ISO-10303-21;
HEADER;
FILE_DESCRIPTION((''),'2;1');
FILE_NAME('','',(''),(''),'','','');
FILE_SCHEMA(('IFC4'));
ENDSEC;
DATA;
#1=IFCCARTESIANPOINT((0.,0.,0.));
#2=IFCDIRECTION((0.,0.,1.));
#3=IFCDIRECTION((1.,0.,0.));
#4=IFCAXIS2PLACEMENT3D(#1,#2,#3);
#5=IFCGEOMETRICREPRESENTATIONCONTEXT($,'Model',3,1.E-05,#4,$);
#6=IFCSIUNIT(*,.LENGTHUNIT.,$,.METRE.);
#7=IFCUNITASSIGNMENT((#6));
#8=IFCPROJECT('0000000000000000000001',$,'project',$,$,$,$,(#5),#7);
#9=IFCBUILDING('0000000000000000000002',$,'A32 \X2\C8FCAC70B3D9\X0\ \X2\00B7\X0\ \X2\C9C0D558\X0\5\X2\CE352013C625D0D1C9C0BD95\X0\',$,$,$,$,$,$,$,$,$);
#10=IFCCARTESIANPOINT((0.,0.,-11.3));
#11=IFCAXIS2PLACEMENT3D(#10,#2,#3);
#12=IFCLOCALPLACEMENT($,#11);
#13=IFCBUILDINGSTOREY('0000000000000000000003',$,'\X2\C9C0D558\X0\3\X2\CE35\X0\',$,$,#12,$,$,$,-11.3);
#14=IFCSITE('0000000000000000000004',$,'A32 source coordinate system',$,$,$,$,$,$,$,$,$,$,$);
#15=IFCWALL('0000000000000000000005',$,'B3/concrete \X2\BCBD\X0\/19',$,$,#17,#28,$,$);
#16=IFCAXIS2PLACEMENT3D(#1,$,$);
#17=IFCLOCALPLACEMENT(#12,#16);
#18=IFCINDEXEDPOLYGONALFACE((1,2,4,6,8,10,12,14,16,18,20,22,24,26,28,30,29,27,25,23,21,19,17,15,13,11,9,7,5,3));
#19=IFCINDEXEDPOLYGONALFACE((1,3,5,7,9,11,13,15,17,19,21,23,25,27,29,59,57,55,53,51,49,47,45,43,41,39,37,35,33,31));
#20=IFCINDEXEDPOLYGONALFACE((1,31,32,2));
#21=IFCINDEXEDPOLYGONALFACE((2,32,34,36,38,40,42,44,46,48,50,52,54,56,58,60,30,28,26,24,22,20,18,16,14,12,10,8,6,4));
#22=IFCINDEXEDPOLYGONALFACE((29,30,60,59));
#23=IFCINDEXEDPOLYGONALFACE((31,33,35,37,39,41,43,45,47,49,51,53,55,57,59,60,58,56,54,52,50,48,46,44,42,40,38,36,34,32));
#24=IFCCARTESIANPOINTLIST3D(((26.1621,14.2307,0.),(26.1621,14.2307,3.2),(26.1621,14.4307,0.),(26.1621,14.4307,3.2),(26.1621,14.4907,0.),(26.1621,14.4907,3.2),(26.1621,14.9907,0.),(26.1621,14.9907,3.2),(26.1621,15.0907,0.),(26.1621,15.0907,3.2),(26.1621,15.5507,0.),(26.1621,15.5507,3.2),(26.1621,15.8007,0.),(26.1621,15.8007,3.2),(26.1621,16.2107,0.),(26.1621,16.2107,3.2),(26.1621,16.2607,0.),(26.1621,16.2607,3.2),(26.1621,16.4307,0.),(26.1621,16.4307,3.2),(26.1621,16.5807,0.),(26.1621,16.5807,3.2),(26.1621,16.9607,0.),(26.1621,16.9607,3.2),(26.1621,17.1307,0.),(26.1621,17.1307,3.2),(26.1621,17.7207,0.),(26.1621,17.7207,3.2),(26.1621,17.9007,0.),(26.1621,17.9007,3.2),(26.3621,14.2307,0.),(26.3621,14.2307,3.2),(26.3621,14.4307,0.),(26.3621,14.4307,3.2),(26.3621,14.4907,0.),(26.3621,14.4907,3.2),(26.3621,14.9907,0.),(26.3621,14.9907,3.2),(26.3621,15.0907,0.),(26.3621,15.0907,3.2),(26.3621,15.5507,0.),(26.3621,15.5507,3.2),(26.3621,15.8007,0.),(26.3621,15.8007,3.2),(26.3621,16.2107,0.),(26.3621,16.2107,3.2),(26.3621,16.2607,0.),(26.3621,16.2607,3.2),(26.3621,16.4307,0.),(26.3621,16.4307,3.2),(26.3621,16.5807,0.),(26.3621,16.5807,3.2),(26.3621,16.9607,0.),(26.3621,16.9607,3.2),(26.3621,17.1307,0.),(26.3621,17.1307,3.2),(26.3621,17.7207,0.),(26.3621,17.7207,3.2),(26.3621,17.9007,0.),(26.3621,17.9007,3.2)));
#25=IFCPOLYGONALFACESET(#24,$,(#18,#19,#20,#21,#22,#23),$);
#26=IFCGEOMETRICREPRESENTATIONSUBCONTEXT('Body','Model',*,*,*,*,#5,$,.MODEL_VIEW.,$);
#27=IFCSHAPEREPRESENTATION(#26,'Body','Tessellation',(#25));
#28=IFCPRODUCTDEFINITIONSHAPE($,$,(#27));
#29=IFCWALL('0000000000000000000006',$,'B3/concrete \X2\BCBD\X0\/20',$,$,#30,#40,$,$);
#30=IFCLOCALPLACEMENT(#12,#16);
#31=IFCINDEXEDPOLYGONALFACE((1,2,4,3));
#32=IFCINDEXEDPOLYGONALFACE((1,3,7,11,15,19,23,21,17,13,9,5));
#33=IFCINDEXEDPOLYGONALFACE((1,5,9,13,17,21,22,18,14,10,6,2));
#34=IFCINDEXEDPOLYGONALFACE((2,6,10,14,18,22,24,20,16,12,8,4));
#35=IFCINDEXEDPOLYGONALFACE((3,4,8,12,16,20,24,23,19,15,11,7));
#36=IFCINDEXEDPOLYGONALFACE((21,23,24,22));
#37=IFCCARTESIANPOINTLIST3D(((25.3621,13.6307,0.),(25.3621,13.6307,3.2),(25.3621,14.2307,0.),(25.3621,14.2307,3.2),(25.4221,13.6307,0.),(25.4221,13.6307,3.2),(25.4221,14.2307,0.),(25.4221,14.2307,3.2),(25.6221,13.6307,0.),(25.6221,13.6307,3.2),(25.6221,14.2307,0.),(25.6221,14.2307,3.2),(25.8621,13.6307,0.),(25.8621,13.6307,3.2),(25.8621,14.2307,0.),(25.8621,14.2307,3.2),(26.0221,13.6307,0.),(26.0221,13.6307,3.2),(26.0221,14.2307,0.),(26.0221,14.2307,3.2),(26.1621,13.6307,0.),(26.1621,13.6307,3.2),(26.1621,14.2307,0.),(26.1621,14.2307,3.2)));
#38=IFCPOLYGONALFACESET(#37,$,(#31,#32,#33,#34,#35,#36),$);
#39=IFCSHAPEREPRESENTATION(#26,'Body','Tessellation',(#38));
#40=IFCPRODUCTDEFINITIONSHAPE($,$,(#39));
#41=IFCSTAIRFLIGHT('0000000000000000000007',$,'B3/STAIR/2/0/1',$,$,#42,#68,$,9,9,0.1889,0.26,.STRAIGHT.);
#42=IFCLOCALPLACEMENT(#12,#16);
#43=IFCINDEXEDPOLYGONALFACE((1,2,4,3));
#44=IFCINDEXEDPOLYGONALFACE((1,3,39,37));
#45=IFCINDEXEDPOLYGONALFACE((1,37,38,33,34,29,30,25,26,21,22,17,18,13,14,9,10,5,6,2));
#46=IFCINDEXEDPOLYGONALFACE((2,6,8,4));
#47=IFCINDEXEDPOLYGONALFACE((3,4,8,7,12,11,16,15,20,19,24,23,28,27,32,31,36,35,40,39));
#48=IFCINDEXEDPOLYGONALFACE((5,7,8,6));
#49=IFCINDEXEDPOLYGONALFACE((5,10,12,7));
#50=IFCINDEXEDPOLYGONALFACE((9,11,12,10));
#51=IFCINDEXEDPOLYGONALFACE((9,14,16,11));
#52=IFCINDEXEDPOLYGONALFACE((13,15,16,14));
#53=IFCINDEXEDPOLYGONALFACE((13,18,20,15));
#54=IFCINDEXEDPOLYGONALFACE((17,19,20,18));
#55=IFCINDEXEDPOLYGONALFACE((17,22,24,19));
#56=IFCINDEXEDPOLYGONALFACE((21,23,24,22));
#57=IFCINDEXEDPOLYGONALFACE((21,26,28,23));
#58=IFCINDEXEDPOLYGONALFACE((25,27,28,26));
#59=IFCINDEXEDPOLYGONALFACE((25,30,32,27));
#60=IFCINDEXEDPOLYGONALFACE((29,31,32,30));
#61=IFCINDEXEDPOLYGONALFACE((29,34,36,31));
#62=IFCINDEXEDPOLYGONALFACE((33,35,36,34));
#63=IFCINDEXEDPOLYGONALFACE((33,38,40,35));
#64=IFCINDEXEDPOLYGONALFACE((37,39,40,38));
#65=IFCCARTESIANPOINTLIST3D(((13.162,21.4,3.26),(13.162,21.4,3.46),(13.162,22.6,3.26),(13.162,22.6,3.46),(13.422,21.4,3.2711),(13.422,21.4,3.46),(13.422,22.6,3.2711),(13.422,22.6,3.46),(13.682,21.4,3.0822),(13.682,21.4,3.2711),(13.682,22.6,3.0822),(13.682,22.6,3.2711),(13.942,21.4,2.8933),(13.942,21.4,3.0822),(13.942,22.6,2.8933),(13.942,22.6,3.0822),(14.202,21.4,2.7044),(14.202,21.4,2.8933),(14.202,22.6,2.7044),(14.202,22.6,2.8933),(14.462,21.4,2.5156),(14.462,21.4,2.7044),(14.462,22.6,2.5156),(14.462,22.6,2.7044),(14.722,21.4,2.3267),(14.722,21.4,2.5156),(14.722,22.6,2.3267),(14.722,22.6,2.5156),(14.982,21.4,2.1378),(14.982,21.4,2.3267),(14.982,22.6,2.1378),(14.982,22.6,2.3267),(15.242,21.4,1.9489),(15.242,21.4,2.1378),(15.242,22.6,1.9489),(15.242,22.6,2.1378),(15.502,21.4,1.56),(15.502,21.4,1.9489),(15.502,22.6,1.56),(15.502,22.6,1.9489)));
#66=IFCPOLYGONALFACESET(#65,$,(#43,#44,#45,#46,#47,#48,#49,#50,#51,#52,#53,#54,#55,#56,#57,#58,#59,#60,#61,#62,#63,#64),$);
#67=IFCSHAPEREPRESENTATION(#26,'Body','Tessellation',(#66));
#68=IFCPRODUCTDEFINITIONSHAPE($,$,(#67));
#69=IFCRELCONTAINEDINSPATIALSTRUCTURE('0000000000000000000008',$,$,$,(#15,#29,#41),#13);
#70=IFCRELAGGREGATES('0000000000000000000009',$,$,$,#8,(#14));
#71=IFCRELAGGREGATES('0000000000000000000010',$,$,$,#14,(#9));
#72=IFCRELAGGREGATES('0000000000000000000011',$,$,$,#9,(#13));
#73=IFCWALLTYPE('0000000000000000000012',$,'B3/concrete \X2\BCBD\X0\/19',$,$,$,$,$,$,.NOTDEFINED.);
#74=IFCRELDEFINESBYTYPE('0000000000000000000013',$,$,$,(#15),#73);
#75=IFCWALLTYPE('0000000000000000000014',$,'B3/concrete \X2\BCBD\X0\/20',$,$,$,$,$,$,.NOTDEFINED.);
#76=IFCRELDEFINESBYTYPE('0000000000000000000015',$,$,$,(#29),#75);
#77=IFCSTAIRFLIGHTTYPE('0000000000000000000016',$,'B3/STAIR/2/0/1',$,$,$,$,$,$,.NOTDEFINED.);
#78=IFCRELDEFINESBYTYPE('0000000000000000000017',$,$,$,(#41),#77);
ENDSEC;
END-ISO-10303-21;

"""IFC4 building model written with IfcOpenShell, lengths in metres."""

from ifc_helpers import new_model, si_unit, frame, origin, origin_with_axes, place, context, subcontext, project, spatial, polyline, outline, extrude, source, transform, mapped, type_object, type_shapes, element, save


model = new_model("IFC4")

# Units and contexts
model_context = context("Model", 3, precision=1e-05, world=origin_with_axes())
body_context = subcontext(model_context, "Body", "Model", "MODEL_VIEW")
ifc_project = project(units=[si_unit("LENGTHUNIT", "METRE")], contexts=[model_context])

# Site, building, storey
site = spatial("IfcSite", under=ifc_project, Name="A32 source coordinate system")
building = spatial("IfcBuilding", under=site, Name="A32 주거동 · 지하5층–옥탑지붕")
storey_placement = place(None, frame((0.0, 0.0, -11.3), z_axis=(0.0, 0.0, 1.0), x_axis=(1.0, 0.0, 0.0)))
storey = spatial("IfcBuildingStorey", under=building, at=storey_placement, Name="지하3층", Elevation=-11.3)

# Walls
wall_type_1 = type_object("IfcWallType", Name="B3/concrete 벽/19", PredefinedType="NOTDEFINED")
shared_shape_1 = source(origin(), body_context, "Body", "SweptSolid", [
    extrude(outline(polyline([(26.1621, 14.9907), (26.1621, 15.0907), (26.1621, 15.5507), (26.1621, 15.8007), (26.1621, 16.2107), (26.1621, 16.2607), (26.1621, 16.4307), (26.1621, 16.5807), (26.1621, 16.9607), (26.1621, 17.1307), (26.1621, 17.7207), (26.1621, 17.9007), (26.3621, 17.9007), (26.3621, 17.7207), (26.3621, 17.1307), (26.3621, 16.9607), (26.3621, 16.5807), (26.3621, 16.4307), (26.3621, 16.2607), (26.3621, 16.2107), (26.3621, 15.8007), (26.3621, 15.5507), (26.3621, 15.0907), (26.3621, 14.9907), (26.3621, 14.4907), (26.3621, 14.4307), (26.3621, 14.2307), (26.1621, 14.2307), (26.1621, 14.4307), (26.1621, 14.4907), (26.1621, 14.9907)])), origin(), (0.0, 0.0, 1.0), 3.2),
])
type_shapes(wall_type_1, [shared_shape_1])
wall_1_placement = place(storey_placement, origin_with_axes())
element("IfcWall", 1, at=wall_1_placement, inside=storey, type_object=wall_type_1, Name="B3/concrete 벽/19", context=body_context, shape_type="MappedRepresentation", body=[
    mapped(shared_shape_1, transform((0.0, 0.0, 0.0), scale=1.0)),
])
wall_type_2 = type_object("IfcWallType", Name="B3/concrete 벽/20", PredefinedType="NOTDEFINED")
shared_shape_2 = source(origin(), body_context, "Body", "SweptSolid", [
    extrude(outline(polyline([(25.8621, 13.6307), (25.6221, 13.6307), (25.4221, 13.6307), (25.3621, 13.6307), (25.3621, 14.2307), (25.4221, 14.2307), (25.6221, 14.2307), (25.8621, 14.2307), (26.0221, 14.2307), (26.1621, 14.2307), (26.1621, 13.6307), (26.0221, 13.6307), (25.8621, 13.6307)])), origin(), (0.0, 0.0, 1.0), 3.2),
])
type_shapes(wall_type_2, [shared_shape_2])
wall_2_placement = place(storey_placement, origin_with_axes())
element("IfcWall", 2, at=wall_2_placement, inside=storey, type_object=wall_type_2, Name="B3/concrete 벽/20", context=body_context, shape_type="MappedRepresentation", body=[
    mapped(shared_shape_2, transform((0.0, 0.0, 0.0), scale=1.0)),
])

# Stair flight
stair_flight_type = type_object("IfcStairFlightType", Name="B3/STAIR/2/0/1", PredefinedType="NOTDEFINED")
shared_shape_3 = source(origin(), body_context, "Body", "SweptSolid", [
    extrude(outline(polyline([(0.0, 1.56), (2.34, 3.26), (2.34, 3.46), (2.08, 3.46), (2.08, 3.2711), (1.82, 3.2711), (1.82, 3.0822), (1.56, 3.0822), (1.56, 2.8933), (1.3, 2.8933), (1.3, 2.7044), (1.04, 2.7044), (1.04, 2.5156), (0.78, 2.5156), (0.78, 2.3267), (0.52, 2.3267), (0.52, 2.1378), (0.26, 2.1378), (0.26, 1.9489), (0.0, 1.9489), (0.0, 1.56)])), frame((15.502, 21.4, 0.0), z_axis=(0.0, 1.0, 0.0), x_axis=(-1.0, 0.0, 0.0)), (0.0, 0.0, 1.0), 1.2),
])
type_shapes(stair_flight_type, [shared_shape_3])
stair_flight_placement = place(storey_placement, origin_with_axes())
element("IfcStairFlight", 3, at=stair_flight_placement, inside=storey, type_object=stair_flight_type, Name="B3/STAIR/2/0/1", NumberOfRisers=9, NumberOfTreads=9, PredefinedType="STRAIGHT", RiserHeight=0.1889, TreadLength=0.26, context=body_context, shape_type="MappedRepresentation", body=[
    mapped(shared_shape_3, transform((0.0, 0.0, 0.0), scale=1.0)),
])

save(model, "model.ifc")
